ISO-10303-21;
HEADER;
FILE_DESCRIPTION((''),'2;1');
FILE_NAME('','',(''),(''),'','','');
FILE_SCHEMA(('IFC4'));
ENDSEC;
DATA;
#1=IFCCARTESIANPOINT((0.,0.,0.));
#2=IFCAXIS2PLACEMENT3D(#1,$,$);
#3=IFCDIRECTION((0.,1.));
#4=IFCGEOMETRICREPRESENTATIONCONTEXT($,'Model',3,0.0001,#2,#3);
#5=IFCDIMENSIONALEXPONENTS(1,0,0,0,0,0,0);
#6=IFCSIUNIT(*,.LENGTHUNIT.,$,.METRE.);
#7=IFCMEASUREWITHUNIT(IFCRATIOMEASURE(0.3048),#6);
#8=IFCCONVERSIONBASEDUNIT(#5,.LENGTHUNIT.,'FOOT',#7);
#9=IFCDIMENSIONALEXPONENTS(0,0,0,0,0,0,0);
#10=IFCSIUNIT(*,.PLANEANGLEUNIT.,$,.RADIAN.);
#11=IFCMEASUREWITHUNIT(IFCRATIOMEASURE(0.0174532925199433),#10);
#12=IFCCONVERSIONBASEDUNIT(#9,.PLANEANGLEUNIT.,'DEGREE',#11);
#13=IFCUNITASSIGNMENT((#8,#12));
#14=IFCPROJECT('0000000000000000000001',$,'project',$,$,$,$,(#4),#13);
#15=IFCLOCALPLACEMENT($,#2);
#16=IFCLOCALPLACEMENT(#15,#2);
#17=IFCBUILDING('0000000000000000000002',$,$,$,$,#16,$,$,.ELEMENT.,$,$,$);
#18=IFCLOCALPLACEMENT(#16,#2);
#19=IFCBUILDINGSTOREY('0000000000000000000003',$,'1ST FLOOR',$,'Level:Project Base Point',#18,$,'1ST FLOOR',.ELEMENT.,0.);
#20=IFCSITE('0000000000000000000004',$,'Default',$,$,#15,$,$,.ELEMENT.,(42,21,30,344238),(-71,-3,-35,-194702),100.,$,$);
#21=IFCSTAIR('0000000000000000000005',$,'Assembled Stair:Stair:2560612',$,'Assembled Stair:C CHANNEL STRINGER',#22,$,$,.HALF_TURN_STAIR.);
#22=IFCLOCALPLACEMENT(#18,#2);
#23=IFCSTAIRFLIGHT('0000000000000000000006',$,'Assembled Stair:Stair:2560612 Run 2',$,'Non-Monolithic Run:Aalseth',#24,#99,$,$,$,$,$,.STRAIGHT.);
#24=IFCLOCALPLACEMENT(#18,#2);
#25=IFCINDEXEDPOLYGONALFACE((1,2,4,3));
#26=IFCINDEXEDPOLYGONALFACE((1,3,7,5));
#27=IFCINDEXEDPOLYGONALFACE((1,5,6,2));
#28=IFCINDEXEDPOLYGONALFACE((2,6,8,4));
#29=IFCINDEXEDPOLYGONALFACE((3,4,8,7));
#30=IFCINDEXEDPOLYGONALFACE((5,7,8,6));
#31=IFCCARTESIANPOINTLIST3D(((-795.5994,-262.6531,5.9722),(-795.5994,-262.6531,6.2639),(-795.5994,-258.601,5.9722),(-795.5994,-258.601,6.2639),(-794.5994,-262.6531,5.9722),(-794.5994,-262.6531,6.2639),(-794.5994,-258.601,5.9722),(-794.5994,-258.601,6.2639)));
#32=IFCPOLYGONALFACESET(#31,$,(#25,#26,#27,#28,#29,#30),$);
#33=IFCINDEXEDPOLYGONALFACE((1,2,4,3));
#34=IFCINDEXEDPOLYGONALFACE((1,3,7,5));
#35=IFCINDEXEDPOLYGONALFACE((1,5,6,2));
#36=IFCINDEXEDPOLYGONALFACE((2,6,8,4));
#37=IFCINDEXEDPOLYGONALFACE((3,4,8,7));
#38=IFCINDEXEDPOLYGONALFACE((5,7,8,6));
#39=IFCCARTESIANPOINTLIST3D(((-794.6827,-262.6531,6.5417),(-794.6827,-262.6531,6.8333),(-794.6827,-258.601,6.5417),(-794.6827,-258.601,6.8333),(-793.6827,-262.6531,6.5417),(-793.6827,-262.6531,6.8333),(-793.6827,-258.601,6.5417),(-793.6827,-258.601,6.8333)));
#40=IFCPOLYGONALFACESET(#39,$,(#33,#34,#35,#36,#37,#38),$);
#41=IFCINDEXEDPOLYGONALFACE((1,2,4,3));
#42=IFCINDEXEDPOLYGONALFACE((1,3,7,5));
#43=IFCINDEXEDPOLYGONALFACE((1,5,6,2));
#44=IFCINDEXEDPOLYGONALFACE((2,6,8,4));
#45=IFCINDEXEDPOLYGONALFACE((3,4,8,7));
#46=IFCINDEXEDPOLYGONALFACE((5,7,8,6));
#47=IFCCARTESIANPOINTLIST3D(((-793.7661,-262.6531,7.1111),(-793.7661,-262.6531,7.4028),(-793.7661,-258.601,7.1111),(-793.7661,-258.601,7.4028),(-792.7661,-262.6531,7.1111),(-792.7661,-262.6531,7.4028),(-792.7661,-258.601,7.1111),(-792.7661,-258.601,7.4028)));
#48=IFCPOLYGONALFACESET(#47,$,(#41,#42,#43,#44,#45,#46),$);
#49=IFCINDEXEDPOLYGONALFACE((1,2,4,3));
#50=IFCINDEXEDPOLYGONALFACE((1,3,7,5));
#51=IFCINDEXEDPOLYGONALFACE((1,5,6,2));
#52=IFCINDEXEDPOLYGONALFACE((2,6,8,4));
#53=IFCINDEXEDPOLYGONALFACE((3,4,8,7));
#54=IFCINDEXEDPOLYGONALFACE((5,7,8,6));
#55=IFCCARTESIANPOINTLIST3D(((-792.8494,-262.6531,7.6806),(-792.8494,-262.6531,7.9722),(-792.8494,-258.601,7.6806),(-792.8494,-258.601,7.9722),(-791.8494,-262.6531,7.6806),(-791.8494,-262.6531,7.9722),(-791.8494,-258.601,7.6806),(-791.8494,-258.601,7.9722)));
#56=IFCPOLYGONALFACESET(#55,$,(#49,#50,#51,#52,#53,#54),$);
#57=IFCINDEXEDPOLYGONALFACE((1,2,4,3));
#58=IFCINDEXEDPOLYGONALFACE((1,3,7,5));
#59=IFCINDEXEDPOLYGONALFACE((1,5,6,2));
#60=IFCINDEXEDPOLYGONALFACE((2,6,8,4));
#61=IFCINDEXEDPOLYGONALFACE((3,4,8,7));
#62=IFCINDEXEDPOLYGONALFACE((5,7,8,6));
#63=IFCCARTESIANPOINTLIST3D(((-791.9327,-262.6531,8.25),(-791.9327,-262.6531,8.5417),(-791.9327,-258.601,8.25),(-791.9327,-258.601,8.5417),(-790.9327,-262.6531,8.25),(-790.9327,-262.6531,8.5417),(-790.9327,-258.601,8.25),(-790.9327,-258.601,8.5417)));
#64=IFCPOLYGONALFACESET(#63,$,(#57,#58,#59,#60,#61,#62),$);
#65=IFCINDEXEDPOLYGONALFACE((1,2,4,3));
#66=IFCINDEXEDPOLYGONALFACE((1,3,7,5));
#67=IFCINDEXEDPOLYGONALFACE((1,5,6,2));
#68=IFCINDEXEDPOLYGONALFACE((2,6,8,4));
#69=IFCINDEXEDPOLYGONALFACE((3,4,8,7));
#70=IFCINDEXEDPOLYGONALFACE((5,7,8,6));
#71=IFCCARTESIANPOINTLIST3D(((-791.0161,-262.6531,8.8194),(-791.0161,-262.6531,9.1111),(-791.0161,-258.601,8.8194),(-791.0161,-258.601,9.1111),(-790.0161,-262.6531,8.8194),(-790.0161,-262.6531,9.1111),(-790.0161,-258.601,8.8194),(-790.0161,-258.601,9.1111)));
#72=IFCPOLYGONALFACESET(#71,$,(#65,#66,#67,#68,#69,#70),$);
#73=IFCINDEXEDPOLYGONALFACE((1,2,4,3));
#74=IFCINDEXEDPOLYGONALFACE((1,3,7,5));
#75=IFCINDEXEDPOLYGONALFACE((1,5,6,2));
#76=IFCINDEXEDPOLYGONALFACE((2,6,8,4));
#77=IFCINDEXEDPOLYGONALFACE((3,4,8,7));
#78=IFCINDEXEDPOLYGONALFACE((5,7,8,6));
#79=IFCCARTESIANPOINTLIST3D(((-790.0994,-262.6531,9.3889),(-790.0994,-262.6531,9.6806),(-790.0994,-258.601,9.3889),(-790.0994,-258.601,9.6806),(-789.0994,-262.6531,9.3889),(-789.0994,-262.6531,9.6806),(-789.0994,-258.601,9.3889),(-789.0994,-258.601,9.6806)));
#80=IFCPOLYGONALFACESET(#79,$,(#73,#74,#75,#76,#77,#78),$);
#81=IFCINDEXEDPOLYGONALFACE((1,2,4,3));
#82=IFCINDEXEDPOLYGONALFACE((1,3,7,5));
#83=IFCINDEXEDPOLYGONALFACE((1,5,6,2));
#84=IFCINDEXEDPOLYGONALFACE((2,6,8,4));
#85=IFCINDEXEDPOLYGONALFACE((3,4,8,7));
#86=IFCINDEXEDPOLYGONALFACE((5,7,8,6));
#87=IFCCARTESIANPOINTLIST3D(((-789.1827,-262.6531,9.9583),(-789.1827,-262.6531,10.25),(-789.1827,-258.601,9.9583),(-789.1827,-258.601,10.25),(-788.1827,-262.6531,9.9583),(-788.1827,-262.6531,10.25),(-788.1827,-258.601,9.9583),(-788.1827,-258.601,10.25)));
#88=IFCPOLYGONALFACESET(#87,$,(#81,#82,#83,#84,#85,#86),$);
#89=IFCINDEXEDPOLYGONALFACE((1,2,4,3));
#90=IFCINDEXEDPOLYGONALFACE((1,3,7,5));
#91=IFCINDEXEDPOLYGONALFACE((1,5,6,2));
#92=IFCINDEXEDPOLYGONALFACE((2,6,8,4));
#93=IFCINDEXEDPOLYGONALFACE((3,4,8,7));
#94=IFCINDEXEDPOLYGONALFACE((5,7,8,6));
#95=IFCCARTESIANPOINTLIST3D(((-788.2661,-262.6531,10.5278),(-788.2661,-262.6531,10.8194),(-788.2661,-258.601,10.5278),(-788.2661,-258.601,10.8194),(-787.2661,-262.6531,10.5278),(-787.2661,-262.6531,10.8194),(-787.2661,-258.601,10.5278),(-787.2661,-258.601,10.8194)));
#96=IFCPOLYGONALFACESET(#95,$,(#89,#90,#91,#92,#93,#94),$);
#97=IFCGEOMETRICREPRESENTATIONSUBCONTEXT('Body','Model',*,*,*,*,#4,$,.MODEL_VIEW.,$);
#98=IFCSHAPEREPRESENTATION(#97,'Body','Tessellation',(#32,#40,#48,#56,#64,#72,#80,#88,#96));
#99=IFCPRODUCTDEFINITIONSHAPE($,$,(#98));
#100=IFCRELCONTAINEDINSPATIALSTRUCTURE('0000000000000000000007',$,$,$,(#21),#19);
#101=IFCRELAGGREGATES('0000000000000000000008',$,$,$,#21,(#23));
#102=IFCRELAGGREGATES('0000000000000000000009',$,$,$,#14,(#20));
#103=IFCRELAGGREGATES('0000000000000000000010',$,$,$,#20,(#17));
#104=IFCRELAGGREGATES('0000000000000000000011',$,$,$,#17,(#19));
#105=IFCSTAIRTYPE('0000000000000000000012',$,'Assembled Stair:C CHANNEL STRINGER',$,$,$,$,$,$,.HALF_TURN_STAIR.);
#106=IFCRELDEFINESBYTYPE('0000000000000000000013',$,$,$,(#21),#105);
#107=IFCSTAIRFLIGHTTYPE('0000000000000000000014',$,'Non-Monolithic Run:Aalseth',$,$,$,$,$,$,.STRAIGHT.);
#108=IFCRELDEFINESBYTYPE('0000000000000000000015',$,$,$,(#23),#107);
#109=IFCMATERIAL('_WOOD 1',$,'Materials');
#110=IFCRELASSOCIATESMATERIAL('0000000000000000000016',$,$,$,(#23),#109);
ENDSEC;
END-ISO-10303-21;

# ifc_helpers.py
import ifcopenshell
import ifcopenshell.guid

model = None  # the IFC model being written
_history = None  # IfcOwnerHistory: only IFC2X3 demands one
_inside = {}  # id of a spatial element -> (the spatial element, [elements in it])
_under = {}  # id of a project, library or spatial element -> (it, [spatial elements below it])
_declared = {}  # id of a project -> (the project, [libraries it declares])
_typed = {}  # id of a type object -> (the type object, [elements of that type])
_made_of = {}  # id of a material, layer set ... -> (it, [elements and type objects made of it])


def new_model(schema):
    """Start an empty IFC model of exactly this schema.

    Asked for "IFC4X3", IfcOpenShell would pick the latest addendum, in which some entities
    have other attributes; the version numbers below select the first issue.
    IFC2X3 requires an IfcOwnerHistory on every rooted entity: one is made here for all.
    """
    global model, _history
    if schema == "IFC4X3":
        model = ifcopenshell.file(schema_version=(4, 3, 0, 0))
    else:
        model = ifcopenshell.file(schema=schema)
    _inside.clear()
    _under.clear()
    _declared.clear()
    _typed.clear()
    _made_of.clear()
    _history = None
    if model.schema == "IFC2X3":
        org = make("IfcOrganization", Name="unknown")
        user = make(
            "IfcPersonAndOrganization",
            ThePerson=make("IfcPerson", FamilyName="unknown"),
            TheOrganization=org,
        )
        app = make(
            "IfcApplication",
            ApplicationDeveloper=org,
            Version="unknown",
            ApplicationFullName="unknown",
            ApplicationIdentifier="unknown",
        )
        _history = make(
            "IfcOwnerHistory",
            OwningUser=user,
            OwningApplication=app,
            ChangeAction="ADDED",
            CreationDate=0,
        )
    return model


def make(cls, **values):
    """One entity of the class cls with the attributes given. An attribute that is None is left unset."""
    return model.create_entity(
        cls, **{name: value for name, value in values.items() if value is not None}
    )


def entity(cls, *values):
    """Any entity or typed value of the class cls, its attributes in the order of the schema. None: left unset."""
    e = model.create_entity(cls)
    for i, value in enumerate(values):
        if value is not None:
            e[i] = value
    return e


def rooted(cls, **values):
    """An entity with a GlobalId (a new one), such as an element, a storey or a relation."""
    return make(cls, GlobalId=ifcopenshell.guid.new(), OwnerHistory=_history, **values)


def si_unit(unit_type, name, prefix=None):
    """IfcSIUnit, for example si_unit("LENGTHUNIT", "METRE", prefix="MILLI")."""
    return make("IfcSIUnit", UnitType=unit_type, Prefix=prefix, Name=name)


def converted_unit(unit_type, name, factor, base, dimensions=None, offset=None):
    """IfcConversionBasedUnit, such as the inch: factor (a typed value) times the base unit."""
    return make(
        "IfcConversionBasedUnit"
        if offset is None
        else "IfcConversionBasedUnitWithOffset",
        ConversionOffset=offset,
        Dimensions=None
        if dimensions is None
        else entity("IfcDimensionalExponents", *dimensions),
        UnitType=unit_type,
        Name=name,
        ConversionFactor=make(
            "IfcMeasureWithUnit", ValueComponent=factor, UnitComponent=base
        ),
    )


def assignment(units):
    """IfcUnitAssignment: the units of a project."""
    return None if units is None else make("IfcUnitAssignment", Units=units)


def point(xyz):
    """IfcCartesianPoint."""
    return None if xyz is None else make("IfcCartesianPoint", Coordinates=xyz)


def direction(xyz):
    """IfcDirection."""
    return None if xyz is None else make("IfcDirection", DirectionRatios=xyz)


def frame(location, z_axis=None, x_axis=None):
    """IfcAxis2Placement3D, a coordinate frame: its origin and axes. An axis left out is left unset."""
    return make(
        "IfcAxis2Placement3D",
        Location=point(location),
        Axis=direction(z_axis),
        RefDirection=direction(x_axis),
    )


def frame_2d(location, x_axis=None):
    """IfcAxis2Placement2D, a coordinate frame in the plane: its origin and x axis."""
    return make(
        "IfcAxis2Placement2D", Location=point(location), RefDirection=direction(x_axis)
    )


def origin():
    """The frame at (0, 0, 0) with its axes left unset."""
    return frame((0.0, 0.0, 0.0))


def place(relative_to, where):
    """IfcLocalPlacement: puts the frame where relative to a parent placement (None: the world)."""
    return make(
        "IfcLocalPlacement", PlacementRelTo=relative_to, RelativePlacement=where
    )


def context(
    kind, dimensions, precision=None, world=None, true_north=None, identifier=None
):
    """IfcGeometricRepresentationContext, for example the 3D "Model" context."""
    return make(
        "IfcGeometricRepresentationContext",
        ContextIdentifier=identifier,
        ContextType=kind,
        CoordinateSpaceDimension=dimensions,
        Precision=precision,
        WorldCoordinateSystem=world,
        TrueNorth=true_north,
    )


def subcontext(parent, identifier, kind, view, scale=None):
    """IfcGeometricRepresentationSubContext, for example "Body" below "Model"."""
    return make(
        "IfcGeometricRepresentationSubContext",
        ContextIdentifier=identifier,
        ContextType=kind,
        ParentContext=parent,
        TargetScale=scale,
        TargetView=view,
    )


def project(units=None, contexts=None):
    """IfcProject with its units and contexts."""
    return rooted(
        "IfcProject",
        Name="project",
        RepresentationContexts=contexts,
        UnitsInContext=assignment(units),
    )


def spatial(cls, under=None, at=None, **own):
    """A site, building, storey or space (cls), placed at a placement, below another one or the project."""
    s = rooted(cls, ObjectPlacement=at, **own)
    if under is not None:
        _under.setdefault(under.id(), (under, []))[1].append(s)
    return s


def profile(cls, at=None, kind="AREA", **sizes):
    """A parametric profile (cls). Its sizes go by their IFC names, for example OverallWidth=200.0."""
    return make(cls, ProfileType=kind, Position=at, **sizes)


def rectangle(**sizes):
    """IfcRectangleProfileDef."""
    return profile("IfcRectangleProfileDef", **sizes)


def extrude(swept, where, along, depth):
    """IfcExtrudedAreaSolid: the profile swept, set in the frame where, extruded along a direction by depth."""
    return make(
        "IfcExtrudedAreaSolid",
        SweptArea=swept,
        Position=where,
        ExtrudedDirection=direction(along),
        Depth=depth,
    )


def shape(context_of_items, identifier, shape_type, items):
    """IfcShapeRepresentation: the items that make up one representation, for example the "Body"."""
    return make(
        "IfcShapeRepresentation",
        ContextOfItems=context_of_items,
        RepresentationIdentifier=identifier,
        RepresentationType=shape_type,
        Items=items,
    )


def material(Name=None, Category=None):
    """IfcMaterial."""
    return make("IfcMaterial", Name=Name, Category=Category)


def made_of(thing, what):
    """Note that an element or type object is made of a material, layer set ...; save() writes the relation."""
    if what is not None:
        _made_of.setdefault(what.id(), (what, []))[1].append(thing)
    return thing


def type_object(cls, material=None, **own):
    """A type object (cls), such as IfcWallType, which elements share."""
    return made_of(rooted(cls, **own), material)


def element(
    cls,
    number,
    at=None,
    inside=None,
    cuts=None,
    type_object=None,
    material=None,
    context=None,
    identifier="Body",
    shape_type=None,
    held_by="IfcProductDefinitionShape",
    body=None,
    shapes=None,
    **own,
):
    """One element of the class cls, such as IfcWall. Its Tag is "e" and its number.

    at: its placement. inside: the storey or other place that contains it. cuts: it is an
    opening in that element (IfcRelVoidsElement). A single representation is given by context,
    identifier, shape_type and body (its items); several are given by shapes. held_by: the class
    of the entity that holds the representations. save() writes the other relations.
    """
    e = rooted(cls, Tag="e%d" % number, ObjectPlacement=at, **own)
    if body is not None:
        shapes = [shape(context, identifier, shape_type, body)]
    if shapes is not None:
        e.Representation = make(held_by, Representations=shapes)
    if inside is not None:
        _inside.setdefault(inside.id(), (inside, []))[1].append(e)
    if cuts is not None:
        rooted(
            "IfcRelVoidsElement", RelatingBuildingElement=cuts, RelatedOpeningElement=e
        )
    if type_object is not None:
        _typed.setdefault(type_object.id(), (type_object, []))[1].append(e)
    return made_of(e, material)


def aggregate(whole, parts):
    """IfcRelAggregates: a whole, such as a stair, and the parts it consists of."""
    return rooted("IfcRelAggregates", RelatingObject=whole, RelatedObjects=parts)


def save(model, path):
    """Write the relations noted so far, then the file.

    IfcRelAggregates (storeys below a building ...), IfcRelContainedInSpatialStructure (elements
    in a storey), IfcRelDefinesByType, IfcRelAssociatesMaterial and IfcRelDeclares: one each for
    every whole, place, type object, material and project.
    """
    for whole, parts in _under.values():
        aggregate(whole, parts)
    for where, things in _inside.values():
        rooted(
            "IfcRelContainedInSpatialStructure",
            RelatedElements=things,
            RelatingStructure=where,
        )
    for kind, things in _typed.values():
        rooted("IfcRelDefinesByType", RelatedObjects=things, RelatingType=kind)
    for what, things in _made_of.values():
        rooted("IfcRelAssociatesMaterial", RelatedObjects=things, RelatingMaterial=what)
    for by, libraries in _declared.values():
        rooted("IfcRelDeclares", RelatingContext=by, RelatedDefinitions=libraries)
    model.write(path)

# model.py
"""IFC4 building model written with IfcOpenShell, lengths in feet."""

from ifc_helpers import new_model, entity, si_unit, converted_unit, direction, frame, frame_2d, origin, place, context, subcontext, project, spatial, rectangle, extrude, material, type_object, element, aggregate, save


model = new_model("IFC4")

# Units and contexts
model_context = context("Model", 3, precision=0.0001, world=origin(), true_north=direction((0.0, 1.0)))
body_context = subcontext(model_context, "Body", "Model", "MODEL_VIEW")
ifc_project = project(units=[converted_unit("LENGTHUNIT", "FOOT", entity("IfcRatioMeasure", 0.3048), si_unit("LENGTHUNIT", "METRE"), dimensions=[1, 0, 0, 0, 0, 0, 0]), converted_unit("PLANEANGLEUNIT", "DEGREE", entity("IfcRatioMeasure", 0.0174532925199433), si_unit("PLANEANGLEUNIT", "RADIAN"), dimensions=[0, 0, 0, 0, 0, 0, 0])], contexts=[model_context])

# Site, building, storey
site_placement = place(None, origin())
site = spatial("IfcSite", under=ifc_project, at=site_placement, Name="Default", CompositionType="ELEMENT", RefLatitude=(42, 21, 30, 344238), RefLongitude=(-71, -3, -35, -194702), RefElevation=100.0)
building_placement = place(site_placement, origin())
building = spatial("IfcBuilding", under=site, at=building_placement, CompositionType="ELEMENT")
storey_placement = place(building_placement, origin())
storey = spatial("IfcBuildingStorey", under=building, at=storey_placement, Name="1ST FLOOR", ObjectType="Level:Project Base Point", LongName="1ST FLOOR", CompositionType="ELEMENT", Elevation=0.0)

# Stair
stair_type_1 = type_object("IfcStairType", Name="Assembled Stair:C CHANNEL STRINGER", PredefinedType="HALF_TURN_STAIR")
stair_1_placement = place(storey_placement, origin())
stair_1 = element("IfcStair", 1, at=stair_1_placement, inside=storey, type_object=stair_type_1, Name="Assembled Stair:Stair:2560612", ObjectType="Assembled Stair:C CHANNEL STRINGER", PredefinedType="HALF_TURN_STAIR")

# Shared definitions
ifc_material_1 = material(Name="_WOOD 1", Category="Materials")

# Stair flight
stair_flight_type_1 = type_object("IfcStairFlightType", Name="Non-Monolithic Run:Aalseth", PredefinedType="STRAIGHT")
stair_flight_1_placement = place(stair_1_placement, frame((-795.5994, -262.6531, 0.0)))
stair_flight_1 = element("IfcStairFlight", 2, at=stair_flight_1_placement, type_object=stair_flight_type_1, material=ifc_material_1, Name="Assembled Stair:Stair:2560612 Run 2", ObjectType="Non-Monolithic Run:Aalseth", PredefinedType="STRAIGHT", context=body_context, shape_type="SweptSolid", body=[
    extrude(rectangle(XDim=1.0, YDim=4.0521, at=frame_2d((0.0, 0.0), x_axis=(1.0, 0.0))), frame((0.5, 2.026, 5.9722), z_axis=(0.0, 0.0, 1.0), x_axis=(-1.0, 0.0, 0.0)), (0.0, 0.0, 1.0), 0.2917),
    extrude(rectangle(XDim=1.0, YDim=4.0521, at=frame_2d((0.0, 0.0), x_axis=(1.0, 0.0))), frame((1.4167, 2.026, 6.5417), z_axis=(0.0, 0.0, 1.0), x_axis=(-1.0, 0.0, 0.0)), (0.0, 0.0, 1.0), 0.2917),
    extrude(rectangle(XDim=1.0, YDim=4.0521, at=frame_2d((0.0, 0.0), x_axis=(1.0, 0.0))), frame((2.3333, 2.026, 7.1111), z_axis=(0.0, 0.0, 1.0), x_axis=(-1.0, 0.0, 0.0)), (0.0, 0.0, 1.0), 0.2917),
    extrude(rectangle(XDim=1.0, YDim=4.0521, at=frame_2d((0.0, 0.0), x_axis=(1.0, 0.0))), frame((3.25, 2.026, 7.6806), z_axis=(0.0, 0.0, 1.0), x_axis=(-1.0, 0.0, 0.0)), (0.0, 0.0, 1.0), 0.2917),
    extrude(rectangle(XDim=1.0, YDim=4.0521, at=frame_2d((0.0, 0.0), x_axis=(1.0, 0.0))), frame((4.1667, 2.026, 8.25), z_axis=(0.0, 0.0, 1.0), x_axis=(-1.0, 0.0, 0.0)), (0.0, 0.0, 1.0), 0.2917),
    extrude(rectangle(XDim=1.0, YDim=4.0521, at=frame_2d((0.0, 0.0), x_axis=(1.0, 0.0))), frame((5.0833, 2.026, 8.8194), z_axis=(0.0, 0.0, 1.0), x_axis=(-1.0, 0.0, 0.0)), (0.0, 0.0, 1.0), 0.2917),
    extrude(rectangle(XDim=1.0, YDim=4.0521, at=frame_2d((0.0, 0.0), x_axis=(1.0, 0.0))), frame((6.0, 2.026, 9.3889), z_axis=(0.0, 0.0, 1.0), x_axis=(-1.0, 0.0, 0.0)), (0.0, 0.0, 1.0), 0.2917),
    extrude(rectangle(XDim=1.0, YDim=4.0521, at=frame_2d((0.0, 0.0), x_axis=(1.0, 0.0))), frame((6.9167, 2.026, 9.9583), z_axis=(0.0, 0.0, 1.0), x_axis=(-1.0, 0.0, 0.0)), (0.0, 0.0, 1.0), 0.2917),
    extrude(rectangle(XDim=1.0, YDim=4.0521, at=frame_2d((0.0, 0.0), x_axis=(1.0, 0.0))), frame((7.8333, 2.026, 10.5278), z_axis=(0.0, 0.0, 1.0), x_axis=(-1.0, 0.0, 0.0)), (0.0, 0.0, 1.0), 0.2917),
])
aggregate(stair_1, [stair_flight_1])

save(model, "model.ifc")
